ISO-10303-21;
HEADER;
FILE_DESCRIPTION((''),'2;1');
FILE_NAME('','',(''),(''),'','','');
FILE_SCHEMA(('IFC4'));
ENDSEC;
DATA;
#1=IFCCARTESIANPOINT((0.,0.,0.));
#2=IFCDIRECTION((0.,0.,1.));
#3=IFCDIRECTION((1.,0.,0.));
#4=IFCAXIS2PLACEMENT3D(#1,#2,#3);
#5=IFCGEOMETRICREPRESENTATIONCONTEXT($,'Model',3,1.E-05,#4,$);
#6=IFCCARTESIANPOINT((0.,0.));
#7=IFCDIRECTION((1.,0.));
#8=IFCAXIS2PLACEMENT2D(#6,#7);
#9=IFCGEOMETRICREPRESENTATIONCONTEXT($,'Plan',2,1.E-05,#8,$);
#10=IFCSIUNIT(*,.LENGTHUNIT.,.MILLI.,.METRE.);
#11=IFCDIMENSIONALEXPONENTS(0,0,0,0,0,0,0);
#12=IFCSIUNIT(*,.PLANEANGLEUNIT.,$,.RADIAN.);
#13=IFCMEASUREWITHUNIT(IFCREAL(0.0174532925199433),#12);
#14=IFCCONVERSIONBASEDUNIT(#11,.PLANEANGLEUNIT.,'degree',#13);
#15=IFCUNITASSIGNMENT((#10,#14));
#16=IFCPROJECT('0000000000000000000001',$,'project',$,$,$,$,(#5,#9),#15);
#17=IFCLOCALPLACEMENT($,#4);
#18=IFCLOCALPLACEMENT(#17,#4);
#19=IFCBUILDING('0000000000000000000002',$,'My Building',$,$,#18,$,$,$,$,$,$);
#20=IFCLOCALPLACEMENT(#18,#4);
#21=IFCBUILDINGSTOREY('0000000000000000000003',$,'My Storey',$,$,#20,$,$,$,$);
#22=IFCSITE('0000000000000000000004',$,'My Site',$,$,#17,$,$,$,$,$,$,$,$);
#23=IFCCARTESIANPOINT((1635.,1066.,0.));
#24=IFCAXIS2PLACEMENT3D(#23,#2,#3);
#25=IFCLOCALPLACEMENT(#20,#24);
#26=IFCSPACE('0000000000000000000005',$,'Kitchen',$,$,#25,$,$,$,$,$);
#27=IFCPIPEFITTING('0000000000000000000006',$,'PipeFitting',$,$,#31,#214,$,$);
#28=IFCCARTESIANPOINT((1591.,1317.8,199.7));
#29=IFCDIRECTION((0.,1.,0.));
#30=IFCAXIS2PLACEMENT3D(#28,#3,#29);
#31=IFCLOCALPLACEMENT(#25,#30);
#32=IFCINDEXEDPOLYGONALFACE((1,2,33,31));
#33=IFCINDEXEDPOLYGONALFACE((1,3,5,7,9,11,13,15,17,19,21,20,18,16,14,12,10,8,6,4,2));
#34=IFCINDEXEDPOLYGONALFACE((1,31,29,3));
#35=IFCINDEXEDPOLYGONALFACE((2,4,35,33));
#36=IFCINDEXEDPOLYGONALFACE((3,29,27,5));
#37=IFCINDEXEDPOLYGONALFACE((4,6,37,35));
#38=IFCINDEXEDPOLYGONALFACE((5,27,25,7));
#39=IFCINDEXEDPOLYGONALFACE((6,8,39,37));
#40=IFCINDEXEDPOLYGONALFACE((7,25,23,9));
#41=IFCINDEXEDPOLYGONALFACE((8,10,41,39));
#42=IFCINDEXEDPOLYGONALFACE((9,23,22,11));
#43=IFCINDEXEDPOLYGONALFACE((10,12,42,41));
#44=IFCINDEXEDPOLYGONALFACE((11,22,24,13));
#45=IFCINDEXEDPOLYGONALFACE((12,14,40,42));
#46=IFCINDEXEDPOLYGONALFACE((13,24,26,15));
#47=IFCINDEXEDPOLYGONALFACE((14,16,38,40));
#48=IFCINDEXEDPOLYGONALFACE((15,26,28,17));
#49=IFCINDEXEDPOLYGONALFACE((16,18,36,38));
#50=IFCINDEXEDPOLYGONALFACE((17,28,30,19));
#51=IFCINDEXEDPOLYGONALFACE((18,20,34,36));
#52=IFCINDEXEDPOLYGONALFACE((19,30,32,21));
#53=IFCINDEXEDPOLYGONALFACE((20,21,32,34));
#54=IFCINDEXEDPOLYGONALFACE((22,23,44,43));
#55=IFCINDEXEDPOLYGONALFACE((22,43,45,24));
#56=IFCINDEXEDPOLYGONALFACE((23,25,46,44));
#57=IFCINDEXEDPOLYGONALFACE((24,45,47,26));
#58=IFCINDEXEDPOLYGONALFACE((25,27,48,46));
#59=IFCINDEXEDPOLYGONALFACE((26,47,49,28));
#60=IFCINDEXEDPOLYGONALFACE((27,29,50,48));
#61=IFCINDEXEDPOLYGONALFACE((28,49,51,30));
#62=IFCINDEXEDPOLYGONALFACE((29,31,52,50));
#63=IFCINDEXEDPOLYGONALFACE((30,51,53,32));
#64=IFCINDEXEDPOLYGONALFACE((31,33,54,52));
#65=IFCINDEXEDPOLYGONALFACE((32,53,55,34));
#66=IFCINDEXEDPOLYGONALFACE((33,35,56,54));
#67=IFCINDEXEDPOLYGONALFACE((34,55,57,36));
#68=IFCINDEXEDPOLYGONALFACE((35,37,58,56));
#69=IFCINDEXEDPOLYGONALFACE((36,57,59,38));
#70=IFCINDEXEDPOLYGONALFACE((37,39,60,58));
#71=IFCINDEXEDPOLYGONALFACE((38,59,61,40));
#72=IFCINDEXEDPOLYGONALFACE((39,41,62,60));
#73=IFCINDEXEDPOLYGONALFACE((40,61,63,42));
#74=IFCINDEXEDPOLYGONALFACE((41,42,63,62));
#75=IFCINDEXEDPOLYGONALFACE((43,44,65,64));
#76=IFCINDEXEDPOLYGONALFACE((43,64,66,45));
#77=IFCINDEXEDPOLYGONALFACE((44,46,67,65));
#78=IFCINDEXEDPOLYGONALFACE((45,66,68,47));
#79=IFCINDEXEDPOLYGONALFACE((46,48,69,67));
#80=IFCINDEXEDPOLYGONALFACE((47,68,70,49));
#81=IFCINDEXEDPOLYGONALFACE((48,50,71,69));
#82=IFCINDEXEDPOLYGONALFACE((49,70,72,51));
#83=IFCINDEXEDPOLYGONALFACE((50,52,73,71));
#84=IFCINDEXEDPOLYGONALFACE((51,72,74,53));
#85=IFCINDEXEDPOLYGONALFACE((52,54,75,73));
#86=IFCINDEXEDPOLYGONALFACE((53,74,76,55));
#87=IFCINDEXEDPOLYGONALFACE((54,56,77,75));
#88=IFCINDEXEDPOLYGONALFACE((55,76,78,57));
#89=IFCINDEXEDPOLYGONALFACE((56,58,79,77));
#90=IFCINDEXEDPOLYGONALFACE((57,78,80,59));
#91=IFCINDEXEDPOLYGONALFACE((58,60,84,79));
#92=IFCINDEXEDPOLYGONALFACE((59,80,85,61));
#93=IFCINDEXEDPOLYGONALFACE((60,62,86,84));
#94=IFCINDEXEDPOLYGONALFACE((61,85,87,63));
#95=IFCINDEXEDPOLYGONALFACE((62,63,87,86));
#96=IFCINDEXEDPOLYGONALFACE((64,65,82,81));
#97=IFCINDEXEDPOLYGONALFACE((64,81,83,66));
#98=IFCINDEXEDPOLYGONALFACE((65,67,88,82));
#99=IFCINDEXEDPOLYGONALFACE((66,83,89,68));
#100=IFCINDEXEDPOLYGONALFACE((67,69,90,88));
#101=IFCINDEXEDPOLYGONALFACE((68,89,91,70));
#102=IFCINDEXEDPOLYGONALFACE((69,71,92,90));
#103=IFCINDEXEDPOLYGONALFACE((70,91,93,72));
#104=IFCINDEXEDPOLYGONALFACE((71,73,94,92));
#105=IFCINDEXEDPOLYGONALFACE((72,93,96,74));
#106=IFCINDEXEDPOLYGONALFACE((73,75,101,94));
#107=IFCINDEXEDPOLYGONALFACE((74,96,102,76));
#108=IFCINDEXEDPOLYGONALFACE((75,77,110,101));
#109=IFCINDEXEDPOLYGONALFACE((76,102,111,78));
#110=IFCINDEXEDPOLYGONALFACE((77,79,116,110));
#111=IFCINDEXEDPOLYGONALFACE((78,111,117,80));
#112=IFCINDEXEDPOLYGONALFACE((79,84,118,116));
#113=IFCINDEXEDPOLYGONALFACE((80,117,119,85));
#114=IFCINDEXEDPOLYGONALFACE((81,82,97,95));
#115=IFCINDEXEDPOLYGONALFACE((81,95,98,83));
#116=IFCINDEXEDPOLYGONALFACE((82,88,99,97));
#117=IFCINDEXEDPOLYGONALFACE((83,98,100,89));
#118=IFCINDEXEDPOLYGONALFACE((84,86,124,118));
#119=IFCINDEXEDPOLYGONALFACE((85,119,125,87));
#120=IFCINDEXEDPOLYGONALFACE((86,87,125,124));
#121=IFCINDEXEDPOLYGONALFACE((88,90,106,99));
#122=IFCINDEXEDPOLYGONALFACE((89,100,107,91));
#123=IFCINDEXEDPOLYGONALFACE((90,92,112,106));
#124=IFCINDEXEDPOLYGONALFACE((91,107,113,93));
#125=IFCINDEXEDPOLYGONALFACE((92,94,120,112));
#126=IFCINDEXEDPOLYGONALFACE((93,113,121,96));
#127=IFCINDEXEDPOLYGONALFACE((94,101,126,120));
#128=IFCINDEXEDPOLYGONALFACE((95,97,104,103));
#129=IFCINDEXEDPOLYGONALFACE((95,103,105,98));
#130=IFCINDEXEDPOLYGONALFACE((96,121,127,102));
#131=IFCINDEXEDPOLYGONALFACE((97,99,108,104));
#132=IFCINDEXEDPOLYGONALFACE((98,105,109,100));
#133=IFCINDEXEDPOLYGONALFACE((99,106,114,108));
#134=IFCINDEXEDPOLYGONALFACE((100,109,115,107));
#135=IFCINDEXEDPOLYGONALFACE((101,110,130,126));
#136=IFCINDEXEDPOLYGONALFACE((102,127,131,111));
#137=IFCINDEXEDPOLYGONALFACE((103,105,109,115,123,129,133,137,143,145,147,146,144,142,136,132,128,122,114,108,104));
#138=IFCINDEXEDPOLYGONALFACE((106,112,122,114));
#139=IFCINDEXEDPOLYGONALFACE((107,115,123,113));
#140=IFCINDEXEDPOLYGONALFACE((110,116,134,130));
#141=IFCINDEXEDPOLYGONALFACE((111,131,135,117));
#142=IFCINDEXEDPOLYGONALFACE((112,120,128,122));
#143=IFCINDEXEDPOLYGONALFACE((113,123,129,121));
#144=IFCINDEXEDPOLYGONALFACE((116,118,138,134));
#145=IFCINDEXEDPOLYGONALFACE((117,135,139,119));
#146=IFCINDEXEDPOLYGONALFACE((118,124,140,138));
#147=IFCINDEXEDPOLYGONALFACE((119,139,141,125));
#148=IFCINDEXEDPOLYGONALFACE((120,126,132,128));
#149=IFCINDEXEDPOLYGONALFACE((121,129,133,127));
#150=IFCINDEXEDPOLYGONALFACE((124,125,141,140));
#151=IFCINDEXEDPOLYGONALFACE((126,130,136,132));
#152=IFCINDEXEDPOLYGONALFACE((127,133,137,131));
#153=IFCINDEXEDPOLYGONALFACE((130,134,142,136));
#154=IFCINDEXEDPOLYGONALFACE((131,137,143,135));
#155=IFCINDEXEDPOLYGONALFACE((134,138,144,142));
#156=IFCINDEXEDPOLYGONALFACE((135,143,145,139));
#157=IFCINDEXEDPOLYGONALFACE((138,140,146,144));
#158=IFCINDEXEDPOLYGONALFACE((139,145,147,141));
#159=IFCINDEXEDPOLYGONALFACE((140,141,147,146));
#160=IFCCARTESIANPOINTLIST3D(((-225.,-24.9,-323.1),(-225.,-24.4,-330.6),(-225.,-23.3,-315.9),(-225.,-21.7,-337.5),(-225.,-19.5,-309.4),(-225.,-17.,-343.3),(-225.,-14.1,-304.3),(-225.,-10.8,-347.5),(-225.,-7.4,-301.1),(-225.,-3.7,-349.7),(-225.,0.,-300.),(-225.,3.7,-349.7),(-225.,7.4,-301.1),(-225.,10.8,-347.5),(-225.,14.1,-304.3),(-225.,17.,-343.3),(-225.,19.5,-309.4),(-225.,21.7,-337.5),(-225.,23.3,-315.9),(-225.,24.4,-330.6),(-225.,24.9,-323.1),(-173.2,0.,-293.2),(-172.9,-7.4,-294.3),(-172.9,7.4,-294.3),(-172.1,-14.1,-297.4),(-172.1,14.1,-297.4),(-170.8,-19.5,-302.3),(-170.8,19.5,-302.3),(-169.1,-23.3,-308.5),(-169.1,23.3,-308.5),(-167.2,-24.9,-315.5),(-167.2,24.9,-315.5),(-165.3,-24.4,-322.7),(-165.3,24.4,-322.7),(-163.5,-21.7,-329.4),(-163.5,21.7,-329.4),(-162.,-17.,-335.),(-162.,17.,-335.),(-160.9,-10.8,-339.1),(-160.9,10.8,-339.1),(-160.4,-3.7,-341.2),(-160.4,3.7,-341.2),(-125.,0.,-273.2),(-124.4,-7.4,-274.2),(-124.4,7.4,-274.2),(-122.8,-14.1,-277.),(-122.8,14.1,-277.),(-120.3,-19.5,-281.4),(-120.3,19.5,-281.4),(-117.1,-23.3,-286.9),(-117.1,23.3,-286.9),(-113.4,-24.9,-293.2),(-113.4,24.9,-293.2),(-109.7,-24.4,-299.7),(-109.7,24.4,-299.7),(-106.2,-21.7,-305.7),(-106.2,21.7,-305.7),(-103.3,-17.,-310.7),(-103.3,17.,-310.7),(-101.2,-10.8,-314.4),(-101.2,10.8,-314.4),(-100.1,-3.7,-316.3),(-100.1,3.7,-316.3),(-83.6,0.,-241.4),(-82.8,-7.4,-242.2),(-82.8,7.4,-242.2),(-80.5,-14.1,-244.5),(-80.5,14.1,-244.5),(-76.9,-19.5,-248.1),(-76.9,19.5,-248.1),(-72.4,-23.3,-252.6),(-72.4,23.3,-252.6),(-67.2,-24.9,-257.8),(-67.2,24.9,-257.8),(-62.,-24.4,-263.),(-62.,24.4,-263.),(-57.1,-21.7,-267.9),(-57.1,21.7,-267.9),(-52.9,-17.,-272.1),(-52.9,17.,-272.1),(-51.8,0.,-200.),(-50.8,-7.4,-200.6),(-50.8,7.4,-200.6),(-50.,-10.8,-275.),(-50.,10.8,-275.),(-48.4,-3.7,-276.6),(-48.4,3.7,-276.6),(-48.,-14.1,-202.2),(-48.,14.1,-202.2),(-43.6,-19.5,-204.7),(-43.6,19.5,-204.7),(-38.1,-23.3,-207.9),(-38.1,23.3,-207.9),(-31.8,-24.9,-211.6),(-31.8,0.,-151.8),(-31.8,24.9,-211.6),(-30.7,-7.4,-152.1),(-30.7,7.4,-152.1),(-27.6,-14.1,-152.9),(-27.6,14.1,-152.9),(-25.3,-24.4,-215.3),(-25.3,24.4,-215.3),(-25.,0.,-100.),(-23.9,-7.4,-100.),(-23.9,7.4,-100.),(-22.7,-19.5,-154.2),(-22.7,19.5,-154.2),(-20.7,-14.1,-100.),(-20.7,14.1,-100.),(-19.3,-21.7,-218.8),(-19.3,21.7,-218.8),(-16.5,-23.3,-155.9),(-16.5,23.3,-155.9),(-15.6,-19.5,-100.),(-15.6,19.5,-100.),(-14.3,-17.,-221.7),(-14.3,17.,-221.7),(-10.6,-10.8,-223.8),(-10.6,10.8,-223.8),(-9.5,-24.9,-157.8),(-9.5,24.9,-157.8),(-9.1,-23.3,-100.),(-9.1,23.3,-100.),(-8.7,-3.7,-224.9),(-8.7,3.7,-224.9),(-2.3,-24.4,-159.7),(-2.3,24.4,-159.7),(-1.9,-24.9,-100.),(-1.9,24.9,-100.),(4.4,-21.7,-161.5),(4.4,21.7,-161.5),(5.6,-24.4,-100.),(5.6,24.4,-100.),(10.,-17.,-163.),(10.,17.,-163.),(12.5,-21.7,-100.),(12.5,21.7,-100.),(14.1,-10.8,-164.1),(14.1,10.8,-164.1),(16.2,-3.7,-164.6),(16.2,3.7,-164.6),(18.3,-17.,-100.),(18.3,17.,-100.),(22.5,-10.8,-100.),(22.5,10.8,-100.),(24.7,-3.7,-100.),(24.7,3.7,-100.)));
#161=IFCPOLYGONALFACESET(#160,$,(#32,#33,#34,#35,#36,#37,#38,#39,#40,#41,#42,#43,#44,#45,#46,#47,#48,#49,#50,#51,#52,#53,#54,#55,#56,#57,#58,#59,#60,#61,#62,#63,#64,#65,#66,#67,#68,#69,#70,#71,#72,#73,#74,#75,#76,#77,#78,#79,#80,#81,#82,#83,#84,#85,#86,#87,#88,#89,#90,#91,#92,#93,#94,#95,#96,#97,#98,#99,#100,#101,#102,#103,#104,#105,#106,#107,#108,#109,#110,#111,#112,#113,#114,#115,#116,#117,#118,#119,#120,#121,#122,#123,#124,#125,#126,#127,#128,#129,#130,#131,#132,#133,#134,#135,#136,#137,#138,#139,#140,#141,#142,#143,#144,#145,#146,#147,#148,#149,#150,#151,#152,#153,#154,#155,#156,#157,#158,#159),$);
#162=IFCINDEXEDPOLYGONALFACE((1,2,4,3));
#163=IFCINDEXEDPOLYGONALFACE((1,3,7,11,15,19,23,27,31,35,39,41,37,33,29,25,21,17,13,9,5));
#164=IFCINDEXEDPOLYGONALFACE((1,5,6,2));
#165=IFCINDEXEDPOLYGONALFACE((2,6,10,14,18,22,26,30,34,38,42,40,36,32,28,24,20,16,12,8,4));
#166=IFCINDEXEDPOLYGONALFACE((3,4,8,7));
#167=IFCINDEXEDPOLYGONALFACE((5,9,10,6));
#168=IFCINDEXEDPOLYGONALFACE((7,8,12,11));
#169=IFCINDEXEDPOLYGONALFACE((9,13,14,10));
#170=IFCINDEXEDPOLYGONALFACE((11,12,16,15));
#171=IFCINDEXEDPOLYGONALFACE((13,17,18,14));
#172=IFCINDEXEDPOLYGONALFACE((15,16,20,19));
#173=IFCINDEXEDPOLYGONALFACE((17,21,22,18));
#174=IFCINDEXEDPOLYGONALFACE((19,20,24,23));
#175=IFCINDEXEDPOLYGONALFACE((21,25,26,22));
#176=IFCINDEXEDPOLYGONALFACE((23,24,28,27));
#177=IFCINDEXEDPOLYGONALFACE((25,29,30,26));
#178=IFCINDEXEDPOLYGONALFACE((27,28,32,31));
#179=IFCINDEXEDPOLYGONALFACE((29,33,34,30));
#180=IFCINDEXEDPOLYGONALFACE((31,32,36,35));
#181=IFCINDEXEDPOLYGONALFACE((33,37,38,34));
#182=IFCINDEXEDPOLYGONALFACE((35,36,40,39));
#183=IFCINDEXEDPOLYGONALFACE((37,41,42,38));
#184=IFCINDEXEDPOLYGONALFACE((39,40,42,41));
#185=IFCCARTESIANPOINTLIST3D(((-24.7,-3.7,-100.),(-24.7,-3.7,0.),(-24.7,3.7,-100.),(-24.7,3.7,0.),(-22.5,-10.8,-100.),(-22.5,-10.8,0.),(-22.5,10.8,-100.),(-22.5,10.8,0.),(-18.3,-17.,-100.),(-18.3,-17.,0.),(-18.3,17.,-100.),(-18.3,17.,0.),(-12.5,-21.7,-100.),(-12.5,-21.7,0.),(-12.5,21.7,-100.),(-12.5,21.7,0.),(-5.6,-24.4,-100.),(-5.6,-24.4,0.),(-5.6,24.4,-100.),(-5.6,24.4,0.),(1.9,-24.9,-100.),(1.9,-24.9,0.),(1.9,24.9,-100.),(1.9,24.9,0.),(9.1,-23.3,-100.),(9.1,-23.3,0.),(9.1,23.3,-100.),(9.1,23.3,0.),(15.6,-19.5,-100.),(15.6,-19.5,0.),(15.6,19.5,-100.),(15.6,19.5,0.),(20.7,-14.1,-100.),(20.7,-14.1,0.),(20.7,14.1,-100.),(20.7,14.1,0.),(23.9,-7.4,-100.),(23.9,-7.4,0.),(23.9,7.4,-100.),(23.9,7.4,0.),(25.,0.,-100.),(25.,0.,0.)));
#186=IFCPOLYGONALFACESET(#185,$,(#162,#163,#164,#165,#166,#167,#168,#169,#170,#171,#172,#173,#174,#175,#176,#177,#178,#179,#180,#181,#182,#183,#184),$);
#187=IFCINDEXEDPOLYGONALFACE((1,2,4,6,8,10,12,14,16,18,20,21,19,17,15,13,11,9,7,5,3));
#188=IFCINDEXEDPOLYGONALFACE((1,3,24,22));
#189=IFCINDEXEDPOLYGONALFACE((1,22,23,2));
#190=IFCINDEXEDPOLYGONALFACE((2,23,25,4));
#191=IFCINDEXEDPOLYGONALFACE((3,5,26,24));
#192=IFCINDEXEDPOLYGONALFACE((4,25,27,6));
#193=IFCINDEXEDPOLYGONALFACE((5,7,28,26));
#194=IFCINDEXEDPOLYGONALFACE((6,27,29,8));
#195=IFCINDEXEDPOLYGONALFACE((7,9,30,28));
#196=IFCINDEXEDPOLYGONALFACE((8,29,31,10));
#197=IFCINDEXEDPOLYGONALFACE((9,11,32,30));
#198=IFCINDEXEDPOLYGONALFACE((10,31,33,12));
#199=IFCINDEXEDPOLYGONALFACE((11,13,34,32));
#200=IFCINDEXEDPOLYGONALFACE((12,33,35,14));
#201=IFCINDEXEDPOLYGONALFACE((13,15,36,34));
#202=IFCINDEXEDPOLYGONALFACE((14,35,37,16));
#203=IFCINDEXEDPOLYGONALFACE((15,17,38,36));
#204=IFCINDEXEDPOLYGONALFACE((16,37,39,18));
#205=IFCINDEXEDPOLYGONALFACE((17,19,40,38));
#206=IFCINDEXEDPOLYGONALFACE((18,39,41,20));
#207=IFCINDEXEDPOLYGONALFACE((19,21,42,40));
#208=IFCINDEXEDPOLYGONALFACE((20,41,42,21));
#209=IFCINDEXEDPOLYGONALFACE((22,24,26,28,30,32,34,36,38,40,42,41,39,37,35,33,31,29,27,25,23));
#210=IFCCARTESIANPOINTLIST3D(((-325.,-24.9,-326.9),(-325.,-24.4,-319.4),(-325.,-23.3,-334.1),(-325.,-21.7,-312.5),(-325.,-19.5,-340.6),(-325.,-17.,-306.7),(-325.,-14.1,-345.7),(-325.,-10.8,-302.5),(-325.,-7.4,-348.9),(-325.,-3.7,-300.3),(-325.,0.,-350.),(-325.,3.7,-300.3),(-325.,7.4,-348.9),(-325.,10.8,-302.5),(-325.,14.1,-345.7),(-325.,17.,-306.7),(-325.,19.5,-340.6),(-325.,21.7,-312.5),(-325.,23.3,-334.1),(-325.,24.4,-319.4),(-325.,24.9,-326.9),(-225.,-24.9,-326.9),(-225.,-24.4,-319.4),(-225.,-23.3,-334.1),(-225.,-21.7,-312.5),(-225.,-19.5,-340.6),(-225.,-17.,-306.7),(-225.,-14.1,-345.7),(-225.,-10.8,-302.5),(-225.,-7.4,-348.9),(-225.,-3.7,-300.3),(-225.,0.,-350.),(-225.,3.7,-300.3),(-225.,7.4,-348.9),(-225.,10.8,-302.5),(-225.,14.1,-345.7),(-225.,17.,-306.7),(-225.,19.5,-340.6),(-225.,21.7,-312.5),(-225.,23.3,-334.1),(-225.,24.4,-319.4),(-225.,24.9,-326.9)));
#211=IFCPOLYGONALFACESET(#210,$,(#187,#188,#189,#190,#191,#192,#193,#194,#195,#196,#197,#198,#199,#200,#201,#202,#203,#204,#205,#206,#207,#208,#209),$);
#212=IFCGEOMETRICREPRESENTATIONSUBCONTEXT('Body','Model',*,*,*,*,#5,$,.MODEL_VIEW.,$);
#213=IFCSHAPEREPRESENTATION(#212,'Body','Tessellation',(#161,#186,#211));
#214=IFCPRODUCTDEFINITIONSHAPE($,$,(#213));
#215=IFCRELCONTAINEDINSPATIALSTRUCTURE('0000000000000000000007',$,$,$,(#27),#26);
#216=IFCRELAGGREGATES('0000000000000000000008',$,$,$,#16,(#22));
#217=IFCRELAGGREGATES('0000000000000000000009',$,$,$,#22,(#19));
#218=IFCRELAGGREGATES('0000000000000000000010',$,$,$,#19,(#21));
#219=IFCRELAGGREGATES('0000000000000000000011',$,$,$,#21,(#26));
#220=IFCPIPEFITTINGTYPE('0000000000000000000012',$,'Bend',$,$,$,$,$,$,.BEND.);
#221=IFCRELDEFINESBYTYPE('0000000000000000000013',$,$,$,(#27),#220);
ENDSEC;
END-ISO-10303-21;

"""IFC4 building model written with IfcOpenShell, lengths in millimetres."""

from ifc_helpers import new_model, entity, si_unit, converted_unit, frame, origin_with_axes, origin_2d_with_axis, place, context, subcontext, project, spatial, circle, extrude, source, transform, mapped, type_object, type_shapes, element, save


model = new_model("IFC4")

# Units and contexts
model_context = context("Model", 3, precision=1e-05, world=origin_with_axes())
plan_context = context("Plan", 2, precision=1e-05, world=origin_2d_with_axis())
body_context_1 = subcontext(model_context, "Body", "Model", "MODEL_VIEW")
ifc_project = project(units=[si_unit("LENGTHUNIT", "METRE", prefix="MILLI"), converted_unit("PLANEANGLEUNIT", "degree", entity("IfcReal", 0.0174532925199433), si_unit("PLANEANGLEUNIT", "RADIAN"), dimensions=[0, 0, 0, 0, 0, 0, 0])], contexts=[model_context, plan_context])

# Site, building, storey
site_placement = place(None, origin_with_axes())
site = spatial("IfcSite", under=ifc_project, at=site_placement, Name="My Site")
building_placement = place(site_placement, origin_with_axes())
building = spatial("IfcBuilding", under=site, at=building_placement, Name="My Building")
storey_placement = place(building_placement, origin_with_axes())
storey = spatial("IfcBuildingStorey", under=building, at=storey_placement, Name="My Storey")

# Shared definitions
space_1_placement = place(storey_placement, frame((1635.0, 1066.0, 0.0), z_axis=(0.0, 0.0, 1.0), x_axis=(1.0, 0.0, 0.0)))
space_1 = spatial("IfcSpace", under=storey, at=space_1_placement, Name="Kitchen")

# Pipe fitting
pipe_fitting_type = type_object("IfcPipeFittingType", Name="Bend", PredefinedType="BEND")
shared_shape_1 = source(origin_with_axes(), body_context_1, "Body", "AdvancedSweptSolid", [
    entity("IfcSweptDiskSolid", entity("IfcIndexedPolyCurve", entity("IfcCartesianPointList3D", [[0.0, 0.0, -100.0], [-65.9, 0.0, -259.1], [-225.0, 0.0, -325.0]]), [entity("IfcArcIndex", [1, 2, 3])]), 25.0),
    extrude(circle(Radius=25.0), origin_with_axes(), (0.0, 0.0, -1.0), 100.0),
    extrude(circle(Radius=25.0), frame((-225.0, 0.0, -325.0), z_axis=(-1.0, 0.0, 0.0), x_axis=(0.0, 0.0, -1.0)), (0.0, 0.0, 1.0), 100.0),
])
type_shapes(pipe_fitting_type, [shared_shape_1])
pipe_fitting_placement = place(space_1_placement, frame((1591.0, 1317.8, 199.7), z_axis=(1.0, 0.0, 0.0), x_axis=(0.0, 1.0, 0.0)))
element("IfcPipeFitting", 1, at=pipe_fitting_placement, inside=space_1, type_object=pipe_fitting_type, Name="PipeFitting", context=body_context_1, shape_type="MappedRepresentation", body=[
    mapped(shared_shape_1, transform((0.0, 0.0, 0.0), x_axis=(1.0, 0.0, 0.0), y_axis=(0.0, 1.0, 0.0), z_axis=(0.0, 0.0, 1.0), scale=1.0)),
])

save(model, "model.ifc")
